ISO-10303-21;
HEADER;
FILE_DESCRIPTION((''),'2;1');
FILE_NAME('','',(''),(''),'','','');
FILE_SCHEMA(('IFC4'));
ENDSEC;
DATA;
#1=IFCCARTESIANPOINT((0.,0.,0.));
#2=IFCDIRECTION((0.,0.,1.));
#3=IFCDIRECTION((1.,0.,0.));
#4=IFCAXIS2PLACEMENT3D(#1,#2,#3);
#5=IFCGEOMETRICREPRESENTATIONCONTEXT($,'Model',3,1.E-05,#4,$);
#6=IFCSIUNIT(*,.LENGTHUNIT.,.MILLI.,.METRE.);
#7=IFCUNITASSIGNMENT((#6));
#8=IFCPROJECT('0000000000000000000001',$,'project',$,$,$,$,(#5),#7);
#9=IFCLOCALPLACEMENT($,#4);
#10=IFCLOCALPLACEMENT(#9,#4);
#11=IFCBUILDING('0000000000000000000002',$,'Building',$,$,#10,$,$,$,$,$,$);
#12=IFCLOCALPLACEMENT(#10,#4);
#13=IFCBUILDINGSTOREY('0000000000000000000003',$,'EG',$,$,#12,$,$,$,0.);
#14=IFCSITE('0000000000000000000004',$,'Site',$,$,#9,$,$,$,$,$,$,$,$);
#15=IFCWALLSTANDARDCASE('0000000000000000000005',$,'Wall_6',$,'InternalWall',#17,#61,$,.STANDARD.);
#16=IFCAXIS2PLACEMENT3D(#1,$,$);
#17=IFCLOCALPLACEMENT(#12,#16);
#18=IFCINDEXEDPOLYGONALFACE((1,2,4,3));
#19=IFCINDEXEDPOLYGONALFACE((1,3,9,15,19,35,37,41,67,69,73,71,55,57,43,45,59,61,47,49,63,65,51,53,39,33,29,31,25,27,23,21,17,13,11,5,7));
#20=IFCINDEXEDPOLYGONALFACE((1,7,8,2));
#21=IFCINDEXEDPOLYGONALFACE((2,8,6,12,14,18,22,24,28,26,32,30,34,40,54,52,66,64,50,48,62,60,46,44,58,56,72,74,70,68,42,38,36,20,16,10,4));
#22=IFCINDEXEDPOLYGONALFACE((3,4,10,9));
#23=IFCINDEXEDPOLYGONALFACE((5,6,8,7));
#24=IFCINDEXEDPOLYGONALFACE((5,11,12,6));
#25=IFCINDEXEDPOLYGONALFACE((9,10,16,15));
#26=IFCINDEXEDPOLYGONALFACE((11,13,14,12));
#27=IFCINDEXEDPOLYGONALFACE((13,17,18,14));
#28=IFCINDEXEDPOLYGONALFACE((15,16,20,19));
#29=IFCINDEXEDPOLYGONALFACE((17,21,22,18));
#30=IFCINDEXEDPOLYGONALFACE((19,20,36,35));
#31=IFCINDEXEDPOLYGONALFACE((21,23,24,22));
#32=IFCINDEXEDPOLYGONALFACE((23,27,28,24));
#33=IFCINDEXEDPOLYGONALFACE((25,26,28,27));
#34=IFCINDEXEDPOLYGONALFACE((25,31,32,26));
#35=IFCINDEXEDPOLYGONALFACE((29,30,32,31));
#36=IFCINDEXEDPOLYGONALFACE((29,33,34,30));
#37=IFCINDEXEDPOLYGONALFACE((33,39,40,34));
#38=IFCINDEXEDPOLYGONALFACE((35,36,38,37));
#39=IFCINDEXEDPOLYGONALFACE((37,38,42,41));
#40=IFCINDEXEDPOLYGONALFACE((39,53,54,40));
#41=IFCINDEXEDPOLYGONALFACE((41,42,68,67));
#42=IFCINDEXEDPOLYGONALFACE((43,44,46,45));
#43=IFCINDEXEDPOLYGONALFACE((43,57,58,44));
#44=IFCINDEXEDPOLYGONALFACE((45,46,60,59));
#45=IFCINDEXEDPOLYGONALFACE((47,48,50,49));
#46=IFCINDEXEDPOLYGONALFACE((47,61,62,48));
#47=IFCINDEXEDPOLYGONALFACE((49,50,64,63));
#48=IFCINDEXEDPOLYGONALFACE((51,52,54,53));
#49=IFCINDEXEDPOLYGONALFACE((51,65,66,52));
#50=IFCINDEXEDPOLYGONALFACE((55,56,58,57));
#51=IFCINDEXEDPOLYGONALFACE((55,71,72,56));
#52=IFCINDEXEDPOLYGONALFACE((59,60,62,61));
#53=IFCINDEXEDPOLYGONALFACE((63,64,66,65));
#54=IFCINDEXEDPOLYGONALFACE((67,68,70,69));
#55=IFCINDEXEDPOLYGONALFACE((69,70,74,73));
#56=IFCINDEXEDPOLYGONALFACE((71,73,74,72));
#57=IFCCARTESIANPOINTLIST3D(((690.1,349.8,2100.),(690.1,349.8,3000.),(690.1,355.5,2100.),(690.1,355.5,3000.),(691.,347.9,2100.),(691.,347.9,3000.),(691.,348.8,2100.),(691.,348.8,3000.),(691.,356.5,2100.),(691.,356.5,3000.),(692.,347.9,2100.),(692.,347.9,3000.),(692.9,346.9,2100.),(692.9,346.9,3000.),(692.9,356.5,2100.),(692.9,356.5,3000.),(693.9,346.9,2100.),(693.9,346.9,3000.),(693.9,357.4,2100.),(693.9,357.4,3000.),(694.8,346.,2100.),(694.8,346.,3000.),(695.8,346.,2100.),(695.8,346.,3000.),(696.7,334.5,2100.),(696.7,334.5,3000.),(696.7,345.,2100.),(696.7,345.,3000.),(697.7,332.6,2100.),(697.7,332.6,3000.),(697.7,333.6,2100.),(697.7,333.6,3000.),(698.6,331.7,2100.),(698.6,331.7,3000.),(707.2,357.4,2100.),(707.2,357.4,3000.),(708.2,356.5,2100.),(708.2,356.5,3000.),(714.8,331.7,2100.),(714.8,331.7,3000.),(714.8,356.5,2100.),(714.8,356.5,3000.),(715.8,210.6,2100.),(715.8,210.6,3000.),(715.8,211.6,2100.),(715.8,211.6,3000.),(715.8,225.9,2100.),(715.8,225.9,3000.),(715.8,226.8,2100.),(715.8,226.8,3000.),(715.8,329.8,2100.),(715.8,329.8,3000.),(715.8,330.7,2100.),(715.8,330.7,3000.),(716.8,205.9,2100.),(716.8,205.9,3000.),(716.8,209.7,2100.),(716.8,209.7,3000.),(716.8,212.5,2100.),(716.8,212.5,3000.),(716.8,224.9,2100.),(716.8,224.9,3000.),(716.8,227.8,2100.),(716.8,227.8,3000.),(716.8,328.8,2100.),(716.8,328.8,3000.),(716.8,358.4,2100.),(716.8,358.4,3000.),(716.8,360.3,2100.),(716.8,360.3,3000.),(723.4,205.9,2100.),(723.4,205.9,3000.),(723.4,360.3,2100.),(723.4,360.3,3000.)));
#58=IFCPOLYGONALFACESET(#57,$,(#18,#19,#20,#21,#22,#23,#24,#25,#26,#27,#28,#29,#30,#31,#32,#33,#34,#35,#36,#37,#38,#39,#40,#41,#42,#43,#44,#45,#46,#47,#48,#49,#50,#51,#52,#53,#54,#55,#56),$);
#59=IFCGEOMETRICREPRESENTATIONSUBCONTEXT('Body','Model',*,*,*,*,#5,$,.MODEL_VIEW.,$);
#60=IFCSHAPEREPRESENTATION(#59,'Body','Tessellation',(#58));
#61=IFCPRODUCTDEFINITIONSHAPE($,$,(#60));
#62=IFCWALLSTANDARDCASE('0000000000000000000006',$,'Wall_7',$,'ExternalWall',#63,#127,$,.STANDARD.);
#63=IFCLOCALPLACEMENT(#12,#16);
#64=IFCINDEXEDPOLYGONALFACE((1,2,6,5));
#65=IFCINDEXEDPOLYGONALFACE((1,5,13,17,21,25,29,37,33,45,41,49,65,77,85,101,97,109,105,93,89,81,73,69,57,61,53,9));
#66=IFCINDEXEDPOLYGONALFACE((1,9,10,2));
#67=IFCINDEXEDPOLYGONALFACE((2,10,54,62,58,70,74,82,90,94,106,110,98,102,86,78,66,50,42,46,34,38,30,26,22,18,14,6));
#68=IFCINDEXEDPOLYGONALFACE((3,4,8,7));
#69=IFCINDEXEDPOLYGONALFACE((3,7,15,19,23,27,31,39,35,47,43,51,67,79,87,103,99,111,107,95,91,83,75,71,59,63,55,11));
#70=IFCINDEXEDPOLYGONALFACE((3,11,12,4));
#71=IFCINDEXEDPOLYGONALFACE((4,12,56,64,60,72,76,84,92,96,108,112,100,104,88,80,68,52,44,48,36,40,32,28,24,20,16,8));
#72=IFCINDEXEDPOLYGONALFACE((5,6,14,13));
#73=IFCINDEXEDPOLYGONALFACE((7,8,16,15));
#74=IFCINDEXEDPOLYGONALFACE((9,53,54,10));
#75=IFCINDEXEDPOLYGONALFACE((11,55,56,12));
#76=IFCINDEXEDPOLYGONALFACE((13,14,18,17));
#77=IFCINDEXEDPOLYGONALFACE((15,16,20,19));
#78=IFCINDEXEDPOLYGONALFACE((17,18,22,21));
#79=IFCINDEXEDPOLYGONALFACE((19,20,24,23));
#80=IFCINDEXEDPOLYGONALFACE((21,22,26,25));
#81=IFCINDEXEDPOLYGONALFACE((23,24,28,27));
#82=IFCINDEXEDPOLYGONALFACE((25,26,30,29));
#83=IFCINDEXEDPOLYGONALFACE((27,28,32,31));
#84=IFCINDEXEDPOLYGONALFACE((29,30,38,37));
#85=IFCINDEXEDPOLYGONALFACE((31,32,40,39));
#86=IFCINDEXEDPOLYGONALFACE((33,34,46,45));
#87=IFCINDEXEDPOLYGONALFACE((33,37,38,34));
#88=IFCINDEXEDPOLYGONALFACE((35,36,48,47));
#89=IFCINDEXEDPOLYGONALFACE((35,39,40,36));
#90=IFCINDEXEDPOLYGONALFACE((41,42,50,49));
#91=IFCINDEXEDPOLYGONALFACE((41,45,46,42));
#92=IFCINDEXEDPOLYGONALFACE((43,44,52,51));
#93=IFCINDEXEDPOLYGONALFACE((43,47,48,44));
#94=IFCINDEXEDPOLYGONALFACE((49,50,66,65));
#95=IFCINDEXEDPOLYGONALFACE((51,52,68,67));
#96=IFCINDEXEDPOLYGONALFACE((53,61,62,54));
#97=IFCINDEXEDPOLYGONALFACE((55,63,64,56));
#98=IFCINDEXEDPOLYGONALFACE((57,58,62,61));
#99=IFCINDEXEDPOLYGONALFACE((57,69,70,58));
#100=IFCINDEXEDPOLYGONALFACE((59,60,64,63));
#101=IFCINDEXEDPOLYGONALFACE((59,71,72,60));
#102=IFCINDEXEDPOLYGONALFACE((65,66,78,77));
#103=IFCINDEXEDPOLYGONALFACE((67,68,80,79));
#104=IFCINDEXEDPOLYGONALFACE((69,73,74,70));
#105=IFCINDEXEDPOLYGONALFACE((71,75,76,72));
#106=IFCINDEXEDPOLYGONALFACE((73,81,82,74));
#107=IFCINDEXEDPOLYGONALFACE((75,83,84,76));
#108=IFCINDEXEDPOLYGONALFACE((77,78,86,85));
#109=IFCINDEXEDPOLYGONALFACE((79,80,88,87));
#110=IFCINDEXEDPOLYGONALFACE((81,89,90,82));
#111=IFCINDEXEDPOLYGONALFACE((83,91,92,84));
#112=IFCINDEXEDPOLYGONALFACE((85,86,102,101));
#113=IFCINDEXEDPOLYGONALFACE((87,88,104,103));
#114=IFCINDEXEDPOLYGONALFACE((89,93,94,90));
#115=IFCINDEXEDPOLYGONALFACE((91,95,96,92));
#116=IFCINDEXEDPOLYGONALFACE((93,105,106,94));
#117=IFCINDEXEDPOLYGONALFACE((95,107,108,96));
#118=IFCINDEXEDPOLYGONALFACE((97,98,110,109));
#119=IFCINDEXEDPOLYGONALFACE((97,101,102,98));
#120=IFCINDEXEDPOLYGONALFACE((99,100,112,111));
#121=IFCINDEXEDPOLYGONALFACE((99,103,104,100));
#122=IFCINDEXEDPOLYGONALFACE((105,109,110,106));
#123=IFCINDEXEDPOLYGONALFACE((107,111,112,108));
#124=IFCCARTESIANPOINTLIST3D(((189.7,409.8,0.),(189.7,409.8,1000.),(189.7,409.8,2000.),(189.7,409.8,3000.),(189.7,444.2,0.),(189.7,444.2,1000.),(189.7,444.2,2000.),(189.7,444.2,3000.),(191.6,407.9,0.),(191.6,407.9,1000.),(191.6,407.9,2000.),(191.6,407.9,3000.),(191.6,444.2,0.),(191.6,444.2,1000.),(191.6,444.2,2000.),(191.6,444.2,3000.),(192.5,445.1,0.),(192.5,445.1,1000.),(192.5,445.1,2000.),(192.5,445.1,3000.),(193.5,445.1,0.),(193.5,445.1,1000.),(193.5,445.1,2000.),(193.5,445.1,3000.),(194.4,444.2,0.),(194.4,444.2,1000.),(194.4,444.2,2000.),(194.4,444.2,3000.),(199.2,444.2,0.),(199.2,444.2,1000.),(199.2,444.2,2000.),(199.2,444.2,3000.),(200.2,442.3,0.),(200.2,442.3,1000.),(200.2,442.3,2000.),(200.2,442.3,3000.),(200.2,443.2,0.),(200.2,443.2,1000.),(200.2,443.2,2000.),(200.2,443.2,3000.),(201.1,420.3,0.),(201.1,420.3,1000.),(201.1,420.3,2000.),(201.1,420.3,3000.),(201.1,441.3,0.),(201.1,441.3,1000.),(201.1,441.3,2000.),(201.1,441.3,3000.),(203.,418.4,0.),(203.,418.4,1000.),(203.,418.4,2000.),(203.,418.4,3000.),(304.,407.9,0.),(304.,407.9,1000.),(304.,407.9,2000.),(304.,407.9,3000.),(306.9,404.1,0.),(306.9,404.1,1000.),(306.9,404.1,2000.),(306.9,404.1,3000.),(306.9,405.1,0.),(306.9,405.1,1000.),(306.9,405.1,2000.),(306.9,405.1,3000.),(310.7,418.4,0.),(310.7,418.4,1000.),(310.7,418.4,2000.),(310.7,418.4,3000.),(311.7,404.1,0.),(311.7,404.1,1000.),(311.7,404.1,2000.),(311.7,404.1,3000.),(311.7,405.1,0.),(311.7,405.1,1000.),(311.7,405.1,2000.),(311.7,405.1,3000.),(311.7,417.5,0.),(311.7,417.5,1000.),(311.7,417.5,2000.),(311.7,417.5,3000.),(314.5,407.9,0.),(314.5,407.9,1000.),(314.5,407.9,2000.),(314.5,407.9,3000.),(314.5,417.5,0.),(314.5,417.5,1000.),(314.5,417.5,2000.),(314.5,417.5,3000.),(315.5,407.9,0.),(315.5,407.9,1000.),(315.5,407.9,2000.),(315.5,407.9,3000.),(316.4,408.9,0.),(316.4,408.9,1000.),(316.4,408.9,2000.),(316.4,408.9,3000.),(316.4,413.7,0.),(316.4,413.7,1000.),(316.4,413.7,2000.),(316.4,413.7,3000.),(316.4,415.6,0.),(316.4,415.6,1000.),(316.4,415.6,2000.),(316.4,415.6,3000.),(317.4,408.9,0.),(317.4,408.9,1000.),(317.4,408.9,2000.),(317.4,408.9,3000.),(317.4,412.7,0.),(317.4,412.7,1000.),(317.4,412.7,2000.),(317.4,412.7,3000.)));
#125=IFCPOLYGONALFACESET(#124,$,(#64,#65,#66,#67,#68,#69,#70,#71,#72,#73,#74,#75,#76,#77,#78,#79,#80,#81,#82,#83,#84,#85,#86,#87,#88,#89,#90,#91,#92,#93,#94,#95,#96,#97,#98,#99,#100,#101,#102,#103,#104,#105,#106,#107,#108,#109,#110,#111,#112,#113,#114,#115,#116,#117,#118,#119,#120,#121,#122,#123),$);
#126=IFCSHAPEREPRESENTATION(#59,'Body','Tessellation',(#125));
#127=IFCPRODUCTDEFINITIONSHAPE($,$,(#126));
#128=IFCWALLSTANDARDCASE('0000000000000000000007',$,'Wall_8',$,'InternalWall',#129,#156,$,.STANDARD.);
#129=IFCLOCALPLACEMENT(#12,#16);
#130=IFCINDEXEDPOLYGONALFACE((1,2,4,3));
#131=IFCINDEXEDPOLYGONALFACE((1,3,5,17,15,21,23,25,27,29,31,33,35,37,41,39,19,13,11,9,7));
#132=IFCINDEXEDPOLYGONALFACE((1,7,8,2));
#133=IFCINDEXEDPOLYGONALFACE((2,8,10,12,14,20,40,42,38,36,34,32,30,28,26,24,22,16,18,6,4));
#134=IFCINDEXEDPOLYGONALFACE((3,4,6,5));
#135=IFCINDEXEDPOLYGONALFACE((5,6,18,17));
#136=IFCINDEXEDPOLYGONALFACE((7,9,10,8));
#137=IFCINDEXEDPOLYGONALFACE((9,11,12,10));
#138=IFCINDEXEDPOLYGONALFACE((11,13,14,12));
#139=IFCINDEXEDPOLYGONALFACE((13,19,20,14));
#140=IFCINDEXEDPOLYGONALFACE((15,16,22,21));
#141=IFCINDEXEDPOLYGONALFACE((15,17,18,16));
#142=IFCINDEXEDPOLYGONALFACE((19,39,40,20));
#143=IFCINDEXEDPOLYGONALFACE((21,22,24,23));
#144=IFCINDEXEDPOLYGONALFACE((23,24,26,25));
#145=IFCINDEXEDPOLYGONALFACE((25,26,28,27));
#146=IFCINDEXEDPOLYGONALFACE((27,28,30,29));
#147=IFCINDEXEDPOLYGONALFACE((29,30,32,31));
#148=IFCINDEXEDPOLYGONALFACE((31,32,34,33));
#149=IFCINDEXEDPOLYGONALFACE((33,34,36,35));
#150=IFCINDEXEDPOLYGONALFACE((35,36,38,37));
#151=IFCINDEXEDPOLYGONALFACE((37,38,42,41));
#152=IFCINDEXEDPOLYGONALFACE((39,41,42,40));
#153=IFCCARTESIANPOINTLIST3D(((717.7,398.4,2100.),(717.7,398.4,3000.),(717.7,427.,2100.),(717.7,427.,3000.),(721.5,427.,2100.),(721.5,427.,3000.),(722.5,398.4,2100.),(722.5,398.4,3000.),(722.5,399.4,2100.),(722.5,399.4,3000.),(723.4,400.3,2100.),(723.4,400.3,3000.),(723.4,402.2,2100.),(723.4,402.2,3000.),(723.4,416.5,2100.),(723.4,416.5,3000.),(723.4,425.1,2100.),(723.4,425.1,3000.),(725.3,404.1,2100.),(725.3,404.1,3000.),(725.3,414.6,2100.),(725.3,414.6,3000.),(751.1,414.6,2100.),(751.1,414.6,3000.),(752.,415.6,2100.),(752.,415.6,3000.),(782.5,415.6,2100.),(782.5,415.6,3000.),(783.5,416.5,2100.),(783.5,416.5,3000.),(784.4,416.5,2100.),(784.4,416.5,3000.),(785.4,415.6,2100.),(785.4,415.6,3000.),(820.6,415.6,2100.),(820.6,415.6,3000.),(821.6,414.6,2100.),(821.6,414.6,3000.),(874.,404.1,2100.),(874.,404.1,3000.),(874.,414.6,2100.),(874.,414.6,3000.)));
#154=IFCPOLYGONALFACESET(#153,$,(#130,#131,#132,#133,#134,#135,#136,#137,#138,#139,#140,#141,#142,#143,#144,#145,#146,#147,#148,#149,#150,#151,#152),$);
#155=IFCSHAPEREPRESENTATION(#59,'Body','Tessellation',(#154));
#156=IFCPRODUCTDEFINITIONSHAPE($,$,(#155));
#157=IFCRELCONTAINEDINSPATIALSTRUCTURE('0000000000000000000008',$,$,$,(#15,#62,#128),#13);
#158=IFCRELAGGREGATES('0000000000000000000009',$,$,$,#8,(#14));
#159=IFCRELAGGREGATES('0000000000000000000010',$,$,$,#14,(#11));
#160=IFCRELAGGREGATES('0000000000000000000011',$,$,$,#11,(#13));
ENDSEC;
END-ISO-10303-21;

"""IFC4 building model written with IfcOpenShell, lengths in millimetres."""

from ifc_helpers import new_model, si_unit, frame, origin_with_axes, place, context, subcontext, project, spatial, polyline, rectangle, outline, extrude, element, save


model = new_model("IFC4")

# Units and contexts
model_context = context("Model", 3, precision=1e-05, world=origin_with_axes())
body_context = subcontext(model_context, "Body", "Model", "MODEL_VIEW")
ifc_project = project(units=[si_unit("LENGTHUNIT", "METRE", prefix="MILLI")], contexts=[model_context])

# Site, building, storey
site_placement = place(None, origin_with_axes())
site = spatial("IfcSite", under=ifc_project, at=site_placement, Name="Site")
building_placement = place(site_placement, origin_with_axes())
building = spatial("IfcBuilding", under=site, at=building_placement, Name="Building")
storey_placement = place(building_placement, origin_with_axes())
storey = spatial("IfcBuildingStorey", under=building, at=storey_placement, Name="EG", Elevation=0.0)

# Wall, opening
wall_1_placement = place(storey_placement, origin_with_axes())
wall_1 = element("IfcWallStandardCase", 1, at=wall_1_placement, inside=storey, Name="Wall_6", ObjectType="InternalWall", PredefinedType="STANDARD", context=body_context, shape_type="SweptSolid", body=[
    extrude(outline(polyline([(716.8, 205.9, 0.0), (716.8, 209.7, 0.0), (715.8, 210.6, 0.0), (715.8, 211.6, 0.0), (716.8, 212.5, 0.0), (716.8, 224.9, 0.0), (715.8, 225.9, 0.0), (715.8, 226.8, 0.0), (716.8, 227.8, 0.0), (716.8, 328.8, 0.0), (715.8, 329.8, 0.0), (715.8, 330.7, 0.0), (714.8, 331.7, 0.0), (698.6, 331.7, 0.0), (697.7, 332.6, 0.0), (697.7, 333.6, 0.0), (696.7, 334.5, 0.0), (696.7, 345.0, 0.0), (695.8, 346.0, 0.0), (694.8, 346.0, 0.0), (693.9, 346.9, 0.0), (692.9, 346.9, 0.0), (692.0, 347.9, 0.0), (691.0, 347.9, 0.0), (691.0, 348.8, 0.0), (690.1, 349.8, 0.0), (690.1, 355.5, 0.0), (691.0, 356.5, 0.0), (692.9, 356.5, 0.0), (693.9, 357.4, 0.0), (707.2, 357.4, 0.0), (708.2, 356.5, 0.0), (714.8, 356.5, 0.0), (716.8, 358.4, 0.0), (716.8, 360.3, 0.0), (723.4, 360.3, 0.0), (723.4, 205.9, 0.0), (716.8, 205.9, 0.0)])), origin_with_axes(), (0.0, 0.0, 1.0), 3000.0),
])
opening_1_placement = place(wall_1_placement, origin_with_axes())
element("IfcOpeningElement", 2, at=opening_1_placement, inside=storey, cuts=wall_1, context=body_context, shape_type="SweptSolid", body=[
    extrude(rectangle(XDim=450.0, YDim=33.4), frame((706.7, 336.5, 0.0), z_axis=(0.0, 0.0, 1.0), x_axis=(0.0, 1.0, 0.0)), (0.0, 0.0, 1.0), 2100.0),
])

# Walls, openings
wall_2_placement = place(storey_placement, origin_with_axes())
wall_2 = element("IfcWallStandardCase", 3, at=wall_2_placement, inside=storey, Name="Wall_7", ObjectType="ExternalWall", PredefinedType="STANDARD", context=body_context, shape_type="SweptSolid", body=[
    extrude(outline(polyline([(306.9, 404.1, 0.0), (306.9, 405.1, 0.0), (304.0, 407.9, 0.0), (191.6, 407.9, 0.0), (189.7, 409.8, 0.0), (189.7, 444.2, 0.0), (191.6, 444.2, 0.0), (192.5, 445.1, 0.0), (193.5, 445.1, 0.0), (194.4, 444.2, 0.0), (199.2, 444.2, 0.0), (200.2, 443.2, 0.0), (200.2, 442.3, 0.0), (201.1, 441.3, 0.0), (201.1, 420.3, 0.0), (203.0, 418.4, 0.0), (310.7, 418.4, 0.0), (311.7, 417.5, 0.0), (314.5, 417.5, 0.0), (316.4, 415.6, 0.0), (316.4, 413.7, 0.0), (317.4, 412.7, 0.0), (317.4, 408.9, 0.0), (316.4, 408.9, 0.0), (315.5, 407.9, 0.0), (314.5, 407.9, 0.0), (311.7, 405.1, 0.0), (311.7, 404.1, 0.0), (306.9, 404.1, 0.0)])), origin_with_axes(), (0.0, 0.0, 1.0), 3000.0),
])
opening_2_placement = place(wall_2_placement, origin_with_axes())
element("IfcOpeningElement", 4, at=opening_2_placement, inside=storey, cuts=wall_2, context=body_context, shape_type="SweptSolid", body=[
    extrude(rectangle(XDim=600.0, YDim=37.2), frame((194.3, 426.5, 1000.0), z_axis=(0.0, 0.0, 1.0), x_axis=(-0.999454, 0.03304, 0.0)), (0.0, 0.0, 1.0), 1000.0),
])
opening_3_placement = place(wall_2_placement, origin_with_axes())
element("IfcOpeningElement", 5, at=opening_3_placement, inside=storey, cuts=wall_2, context=body_context, shape_type="SweptSolid", body=[
    extrude(rectangle(XDim=600.0, YDim=37.2), frame((189.2, 426.6, 1000.0), z_axis=(0.0, 0.0, 1.0), x_axis=(-0.999454, 0.03304, 0.0)), (0.0, 0.0, 1.0), 1000.0),
])
wall_3_placement = place(storey_placement, origin_with_axes())
wall_3 = element("IfcWallStandardCase", 6, at=wall_3_placement, inside=storey, Name="Wall_8", ObjectType="InternalWall", PredefinedType="STANDARD", context=body_context, shape_type="SweptSolid", body=[
    extrude(outline(polyline([(717.7, 398.4, 0.0), (717.7, 427.0, 0.0), (721.5, 427.0, 0.0), (723.4, 425.1, 0.0), (723.4, 416.5, 0.0), (725.3, 414.6, 0.0), (751.1, 414.6, 0.0), (752.0, 415.6, 0.0), (782.5, 415.6, 0.0), (783.5, 416.5, 0.0), (784.4, 416.5, 0.0), (785.4, 415.6, 0.0), (820.6, 415.6, 0.0), (821.6, 414.6, 0.0), (874.0, 414.6, 0.0), (874.0, 404.1, 0.0), (725.3, 404.1, 0.0), (723.4, 402.2, 0.0), (723.4, 400.3, 0.0), (722.5, 399.4, 0.0), (722.5, 398.4, 0.0), (717.7, 398.4, 0.0)])), origin_with_axes(), (0.0, 0.0, 1.0), 3000.0),
])
opening_4_placement = place(wall_3_placement, origin_with_axes())
element("IfcOpeningElement", 7, at=opening_4_placement, inside=storey, cuts=wall_3, context=body_context, shape_type="SweptSolid", body=[
    extrude(rectangle(XDim=450.0, YDim=28.6), frame((738.2, 412.7, 0.0), z_axis=(0.0, 0.0, 1.0), x_axis=(1.0, 0.0, 0.0)), (0.0, 0.0, 1.0), 2100.0),
])
opening_5_placement = place(wall_3_placement, origin_with_axes())
element("IfcOpeningElement", 8, at=opening_5_placement, inside=storey, cuts=wall_3, context=body_context, shape_type="SweptSolid", body=[
    extrude(rectangle(XDim=450.0, YDim=28.6), frame((733.9, 412.7, 0.0), z_axis=(0.0, 0.0, 1.0), x_axis=(1.0, 0.0, 0.0)), (0.0, 0.0, 1.0), 2100.0),
])

save(model, "model.ifc")
